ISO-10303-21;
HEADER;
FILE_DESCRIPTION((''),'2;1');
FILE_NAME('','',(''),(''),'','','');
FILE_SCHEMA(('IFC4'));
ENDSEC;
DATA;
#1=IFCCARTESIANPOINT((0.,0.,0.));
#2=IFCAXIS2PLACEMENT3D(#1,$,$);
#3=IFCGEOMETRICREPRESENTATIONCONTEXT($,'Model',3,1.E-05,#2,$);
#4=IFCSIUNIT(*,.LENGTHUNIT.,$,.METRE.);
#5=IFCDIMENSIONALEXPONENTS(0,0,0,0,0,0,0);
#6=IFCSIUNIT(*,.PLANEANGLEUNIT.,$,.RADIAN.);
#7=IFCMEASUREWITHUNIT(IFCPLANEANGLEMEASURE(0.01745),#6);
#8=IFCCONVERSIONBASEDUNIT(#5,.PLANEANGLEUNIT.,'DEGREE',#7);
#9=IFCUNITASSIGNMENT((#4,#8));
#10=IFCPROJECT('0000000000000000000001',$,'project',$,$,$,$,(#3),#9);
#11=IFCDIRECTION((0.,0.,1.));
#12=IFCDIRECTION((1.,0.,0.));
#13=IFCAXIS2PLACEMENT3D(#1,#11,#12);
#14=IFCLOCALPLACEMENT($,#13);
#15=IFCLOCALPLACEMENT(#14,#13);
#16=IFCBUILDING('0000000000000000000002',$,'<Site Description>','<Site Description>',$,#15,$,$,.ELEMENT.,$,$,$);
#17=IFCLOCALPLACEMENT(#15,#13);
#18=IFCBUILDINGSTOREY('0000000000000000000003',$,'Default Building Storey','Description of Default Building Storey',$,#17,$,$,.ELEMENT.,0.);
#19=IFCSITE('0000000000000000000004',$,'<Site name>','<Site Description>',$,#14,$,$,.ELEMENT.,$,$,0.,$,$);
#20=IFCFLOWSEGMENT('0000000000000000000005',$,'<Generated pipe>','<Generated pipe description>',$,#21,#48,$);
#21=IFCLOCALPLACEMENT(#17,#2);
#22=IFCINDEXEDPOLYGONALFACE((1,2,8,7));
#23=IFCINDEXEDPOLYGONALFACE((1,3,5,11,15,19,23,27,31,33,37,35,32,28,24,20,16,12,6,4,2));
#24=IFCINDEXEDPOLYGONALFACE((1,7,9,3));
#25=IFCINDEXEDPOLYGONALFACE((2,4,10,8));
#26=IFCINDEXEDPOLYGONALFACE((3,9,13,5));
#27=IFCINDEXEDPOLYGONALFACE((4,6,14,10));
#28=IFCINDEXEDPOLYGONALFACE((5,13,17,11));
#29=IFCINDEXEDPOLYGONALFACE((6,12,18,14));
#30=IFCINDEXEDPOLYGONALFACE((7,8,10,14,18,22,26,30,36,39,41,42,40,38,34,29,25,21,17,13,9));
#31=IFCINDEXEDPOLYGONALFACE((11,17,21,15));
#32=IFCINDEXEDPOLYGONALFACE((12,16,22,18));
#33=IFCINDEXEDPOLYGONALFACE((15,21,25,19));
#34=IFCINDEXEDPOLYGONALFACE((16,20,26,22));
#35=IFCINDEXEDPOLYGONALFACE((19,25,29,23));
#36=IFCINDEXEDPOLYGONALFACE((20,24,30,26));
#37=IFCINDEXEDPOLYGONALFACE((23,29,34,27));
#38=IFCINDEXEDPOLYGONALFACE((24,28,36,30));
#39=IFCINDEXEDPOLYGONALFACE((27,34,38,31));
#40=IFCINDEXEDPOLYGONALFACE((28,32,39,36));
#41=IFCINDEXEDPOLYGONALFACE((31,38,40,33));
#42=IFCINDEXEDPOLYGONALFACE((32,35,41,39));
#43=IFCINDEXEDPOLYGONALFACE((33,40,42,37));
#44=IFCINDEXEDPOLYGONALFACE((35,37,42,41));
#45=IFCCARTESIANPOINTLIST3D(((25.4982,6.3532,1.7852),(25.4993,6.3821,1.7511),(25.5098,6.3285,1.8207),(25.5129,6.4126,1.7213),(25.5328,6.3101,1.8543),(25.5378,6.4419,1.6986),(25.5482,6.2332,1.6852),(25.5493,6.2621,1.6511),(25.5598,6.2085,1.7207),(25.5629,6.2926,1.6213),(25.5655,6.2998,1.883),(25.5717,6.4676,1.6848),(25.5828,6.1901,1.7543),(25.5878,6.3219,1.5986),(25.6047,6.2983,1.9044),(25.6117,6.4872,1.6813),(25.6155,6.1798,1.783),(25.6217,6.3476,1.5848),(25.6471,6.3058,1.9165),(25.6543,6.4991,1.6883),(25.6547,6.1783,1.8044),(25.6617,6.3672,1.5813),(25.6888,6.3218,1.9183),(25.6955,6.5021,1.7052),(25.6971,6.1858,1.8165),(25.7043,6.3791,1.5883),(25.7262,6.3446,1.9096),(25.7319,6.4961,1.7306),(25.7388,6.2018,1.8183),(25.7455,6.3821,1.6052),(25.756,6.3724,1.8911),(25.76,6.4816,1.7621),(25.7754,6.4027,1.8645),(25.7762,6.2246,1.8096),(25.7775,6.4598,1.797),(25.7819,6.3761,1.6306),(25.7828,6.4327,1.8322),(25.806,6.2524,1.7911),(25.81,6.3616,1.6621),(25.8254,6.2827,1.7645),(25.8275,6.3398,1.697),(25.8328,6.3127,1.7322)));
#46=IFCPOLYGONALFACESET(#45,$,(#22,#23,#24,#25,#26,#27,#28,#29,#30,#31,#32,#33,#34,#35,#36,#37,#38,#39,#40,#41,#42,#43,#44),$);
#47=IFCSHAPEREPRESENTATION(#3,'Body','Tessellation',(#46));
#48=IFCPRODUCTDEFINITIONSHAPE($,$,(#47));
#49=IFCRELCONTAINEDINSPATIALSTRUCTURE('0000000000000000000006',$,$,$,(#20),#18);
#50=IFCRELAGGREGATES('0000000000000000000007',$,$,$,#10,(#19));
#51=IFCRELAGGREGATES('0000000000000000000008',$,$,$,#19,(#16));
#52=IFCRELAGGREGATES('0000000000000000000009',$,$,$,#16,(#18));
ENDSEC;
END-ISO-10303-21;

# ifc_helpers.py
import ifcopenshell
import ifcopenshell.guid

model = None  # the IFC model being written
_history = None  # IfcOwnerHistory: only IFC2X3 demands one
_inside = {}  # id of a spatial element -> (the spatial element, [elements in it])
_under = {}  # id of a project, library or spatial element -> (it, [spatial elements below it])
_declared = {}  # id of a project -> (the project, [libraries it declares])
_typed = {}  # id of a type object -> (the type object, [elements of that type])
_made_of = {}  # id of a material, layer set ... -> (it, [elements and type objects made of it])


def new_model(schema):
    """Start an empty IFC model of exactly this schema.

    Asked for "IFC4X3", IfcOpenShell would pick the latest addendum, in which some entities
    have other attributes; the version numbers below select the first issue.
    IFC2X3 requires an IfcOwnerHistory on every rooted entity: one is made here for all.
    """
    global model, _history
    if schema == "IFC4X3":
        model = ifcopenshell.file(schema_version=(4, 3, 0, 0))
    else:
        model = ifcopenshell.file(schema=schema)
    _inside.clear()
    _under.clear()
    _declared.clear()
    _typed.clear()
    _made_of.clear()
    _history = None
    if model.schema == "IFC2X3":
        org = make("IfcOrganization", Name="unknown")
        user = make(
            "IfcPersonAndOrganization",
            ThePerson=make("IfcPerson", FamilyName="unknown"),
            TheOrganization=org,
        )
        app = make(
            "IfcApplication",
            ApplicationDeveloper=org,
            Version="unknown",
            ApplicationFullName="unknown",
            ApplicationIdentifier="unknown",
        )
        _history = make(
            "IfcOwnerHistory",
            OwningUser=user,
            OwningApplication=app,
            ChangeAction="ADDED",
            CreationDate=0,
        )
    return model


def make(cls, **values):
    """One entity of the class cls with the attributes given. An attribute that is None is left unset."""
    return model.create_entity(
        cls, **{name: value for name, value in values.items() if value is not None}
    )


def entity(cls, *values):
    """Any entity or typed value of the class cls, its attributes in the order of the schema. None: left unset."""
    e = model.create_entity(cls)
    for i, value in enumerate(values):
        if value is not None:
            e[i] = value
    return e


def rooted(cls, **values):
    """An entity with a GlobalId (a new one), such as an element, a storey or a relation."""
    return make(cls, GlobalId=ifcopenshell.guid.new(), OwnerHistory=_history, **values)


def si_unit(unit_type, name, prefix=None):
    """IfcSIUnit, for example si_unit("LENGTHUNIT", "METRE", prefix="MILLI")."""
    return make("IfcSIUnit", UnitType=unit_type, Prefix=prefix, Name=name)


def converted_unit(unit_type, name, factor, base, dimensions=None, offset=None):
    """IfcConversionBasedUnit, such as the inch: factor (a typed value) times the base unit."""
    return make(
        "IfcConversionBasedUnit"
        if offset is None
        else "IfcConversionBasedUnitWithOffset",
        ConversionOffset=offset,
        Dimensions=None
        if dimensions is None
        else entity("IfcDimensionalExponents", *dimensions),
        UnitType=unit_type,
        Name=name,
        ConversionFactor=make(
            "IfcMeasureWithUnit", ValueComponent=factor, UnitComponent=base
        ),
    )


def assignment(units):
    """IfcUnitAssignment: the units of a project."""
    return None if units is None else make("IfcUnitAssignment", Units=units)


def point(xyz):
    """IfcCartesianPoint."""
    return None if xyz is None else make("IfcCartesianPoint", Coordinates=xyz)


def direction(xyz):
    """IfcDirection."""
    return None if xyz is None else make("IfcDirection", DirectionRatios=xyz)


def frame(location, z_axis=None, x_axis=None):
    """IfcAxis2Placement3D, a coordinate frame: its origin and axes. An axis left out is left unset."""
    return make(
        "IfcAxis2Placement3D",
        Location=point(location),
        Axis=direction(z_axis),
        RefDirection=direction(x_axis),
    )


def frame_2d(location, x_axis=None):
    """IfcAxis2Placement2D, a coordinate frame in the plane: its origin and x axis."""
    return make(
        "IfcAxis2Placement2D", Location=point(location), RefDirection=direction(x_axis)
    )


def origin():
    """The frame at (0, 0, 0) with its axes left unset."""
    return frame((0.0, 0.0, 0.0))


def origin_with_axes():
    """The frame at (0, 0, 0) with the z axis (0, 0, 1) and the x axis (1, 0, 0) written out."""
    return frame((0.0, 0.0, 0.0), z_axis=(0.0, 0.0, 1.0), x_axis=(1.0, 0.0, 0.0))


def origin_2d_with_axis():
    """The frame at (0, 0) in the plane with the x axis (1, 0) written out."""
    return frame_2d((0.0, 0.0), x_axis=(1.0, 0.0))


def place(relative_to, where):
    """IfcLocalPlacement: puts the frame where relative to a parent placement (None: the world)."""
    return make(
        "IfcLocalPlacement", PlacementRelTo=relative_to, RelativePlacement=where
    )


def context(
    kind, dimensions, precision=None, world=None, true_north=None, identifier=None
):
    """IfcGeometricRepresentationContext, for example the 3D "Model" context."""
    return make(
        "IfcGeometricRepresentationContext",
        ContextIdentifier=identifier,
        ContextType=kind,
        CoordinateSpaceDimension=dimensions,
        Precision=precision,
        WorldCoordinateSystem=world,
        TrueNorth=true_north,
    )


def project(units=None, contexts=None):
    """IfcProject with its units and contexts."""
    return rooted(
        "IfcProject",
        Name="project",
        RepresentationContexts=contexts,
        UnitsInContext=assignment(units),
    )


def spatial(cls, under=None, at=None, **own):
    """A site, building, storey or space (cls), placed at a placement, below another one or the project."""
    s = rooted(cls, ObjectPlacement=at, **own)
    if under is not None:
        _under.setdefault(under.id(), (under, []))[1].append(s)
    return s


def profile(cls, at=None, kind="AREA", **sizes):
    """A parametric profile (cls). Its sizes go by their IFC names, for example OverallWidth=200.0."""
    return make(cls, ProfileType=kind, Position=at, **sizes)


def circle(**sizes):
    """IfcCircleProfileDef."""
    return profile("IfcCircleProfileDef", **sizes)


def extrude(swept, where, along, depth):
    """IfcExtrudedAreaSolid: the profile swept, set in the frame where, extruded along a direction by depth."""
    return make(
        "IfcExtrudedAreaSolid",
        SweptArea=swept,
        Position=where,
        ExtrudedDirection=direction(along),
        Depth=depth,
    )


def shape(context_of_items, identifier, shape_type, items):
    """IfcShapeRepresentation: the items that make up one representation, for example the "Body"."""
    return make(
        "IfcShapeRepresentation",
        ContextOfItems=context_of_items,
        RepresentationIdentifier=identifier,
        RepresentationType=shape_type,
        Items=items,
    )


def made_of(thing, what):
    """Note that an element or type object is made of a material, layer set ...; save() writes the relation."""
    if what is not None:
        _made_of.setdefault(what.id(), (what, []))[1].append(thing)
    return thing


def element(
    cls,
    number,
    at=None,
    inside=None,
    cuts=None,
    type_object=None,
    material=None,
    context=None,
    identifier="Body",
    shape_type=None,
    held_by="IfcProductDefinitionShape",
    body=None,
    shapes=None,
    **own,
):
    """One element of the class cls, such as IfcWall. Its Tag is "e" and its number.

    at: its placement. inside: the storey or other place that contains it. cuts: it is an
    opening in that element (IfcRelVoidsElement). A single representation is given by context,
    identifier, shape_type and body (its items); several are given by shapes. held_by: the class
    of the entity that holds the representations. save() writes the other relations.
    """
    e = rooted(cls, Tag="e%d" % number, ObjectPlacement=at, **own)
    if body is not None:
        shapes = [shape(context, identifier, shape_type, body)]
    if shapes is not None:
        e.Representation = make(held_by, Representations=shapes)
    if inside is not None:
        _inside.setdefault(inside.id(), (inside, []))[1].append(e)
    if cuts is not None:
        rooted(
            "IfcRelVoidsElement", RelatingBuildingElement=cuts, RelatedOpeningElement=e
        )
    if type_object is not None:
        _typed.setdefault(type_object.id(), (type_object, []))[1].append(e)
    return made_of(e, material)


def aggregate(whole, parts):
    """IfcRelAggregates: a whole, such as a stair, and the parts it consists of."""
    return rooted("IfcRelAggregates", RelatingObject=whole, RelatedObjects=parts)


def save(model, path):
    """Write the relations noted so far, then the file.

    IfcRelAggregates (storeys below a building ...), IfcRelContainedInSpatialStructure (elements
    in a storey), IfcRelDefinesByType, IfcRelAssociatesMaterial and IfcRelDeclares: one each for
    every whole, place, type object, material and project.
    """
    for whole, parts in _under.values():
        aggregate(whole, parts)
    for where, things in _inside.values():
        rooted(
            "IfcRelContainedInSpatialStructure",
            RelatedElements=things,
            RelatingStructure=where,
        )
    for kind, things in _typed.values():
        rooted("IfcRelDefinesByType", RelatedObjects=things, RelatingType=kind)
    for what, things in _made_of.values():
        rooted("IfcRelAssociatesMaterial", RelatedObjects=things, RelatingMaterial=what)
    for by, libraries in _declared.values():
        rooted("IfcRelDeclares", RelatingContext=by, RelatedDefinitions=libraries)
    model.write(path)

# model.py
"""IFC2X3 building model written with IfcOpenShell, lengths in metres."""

from ifc_helpers import new_model, entity, si_unit, converted_unit, frame, origin, origin_with_axes, origin_2d_with_axis, place, context, project, spatial, circle, extrude, element, save


model = new_model("IFC2X3")

# Units and contexts
model_context = context("Model", 3, precision=1e-05, world=origin())
ifc_project = project(units=[si_unit("LENGTHUNIT", "METRE"), converted_unit("PLANEANGLEUNIT", "DEGREE", entity("IfcPlaneAngleMeasure", 0.01745), si_unit("PLANEANGLEUNIT", "RADIAN"), dimensions=[0, 0, 0, 0, 0, 0, 0])], contexts=[model_context])

# Site, building, storey
site_placement = place(None, origin_with_axes())
site = spatial("IfcSite", under=ifc_project, at=site_placement, Name="<Site name>", Description="<Site Description>", CompositionType="ELEMENT", RefElevation=0.0)
building_placement = place(site_placement, origin_with_axes())
building = spatial("IfcBuilding", under=site, at=building_placement, Name="<Site Description>", Description="<Site Description>", CompositionType="ELEMENT")
storey_placement = place(building_placement, origin_with_axes())
storey = spatial("IfcBuildingStorey", under=building, at=storey_placement, Name="Default Building Storey", Description="Description of Default Building Storey", CompositionType="ELEMENT", Elevation=0.0)

# Flow segment
flow_segment_1_placement = place(storey_placement, frame((25.64, 6.4, 1.8), z_axis=(0.304855, -0.731653, -0.609711), x_axis=(0.902684, 0.01784, 0.429934)))
element("IfcFlowSegment", 1, at=flow_segment_1_placement, inside=storey, Name="<Generated pipe>", Description="<Generated pipe description>", context=model_context, shape_type="SweptSolid", body=[
    extrude(circle(Radius=0.15, at=origin_2d_with_axis()), origin_with_axes(), (0.0, 0.0, 1.0), 0.164),
])

save(model, "model.ifc")
